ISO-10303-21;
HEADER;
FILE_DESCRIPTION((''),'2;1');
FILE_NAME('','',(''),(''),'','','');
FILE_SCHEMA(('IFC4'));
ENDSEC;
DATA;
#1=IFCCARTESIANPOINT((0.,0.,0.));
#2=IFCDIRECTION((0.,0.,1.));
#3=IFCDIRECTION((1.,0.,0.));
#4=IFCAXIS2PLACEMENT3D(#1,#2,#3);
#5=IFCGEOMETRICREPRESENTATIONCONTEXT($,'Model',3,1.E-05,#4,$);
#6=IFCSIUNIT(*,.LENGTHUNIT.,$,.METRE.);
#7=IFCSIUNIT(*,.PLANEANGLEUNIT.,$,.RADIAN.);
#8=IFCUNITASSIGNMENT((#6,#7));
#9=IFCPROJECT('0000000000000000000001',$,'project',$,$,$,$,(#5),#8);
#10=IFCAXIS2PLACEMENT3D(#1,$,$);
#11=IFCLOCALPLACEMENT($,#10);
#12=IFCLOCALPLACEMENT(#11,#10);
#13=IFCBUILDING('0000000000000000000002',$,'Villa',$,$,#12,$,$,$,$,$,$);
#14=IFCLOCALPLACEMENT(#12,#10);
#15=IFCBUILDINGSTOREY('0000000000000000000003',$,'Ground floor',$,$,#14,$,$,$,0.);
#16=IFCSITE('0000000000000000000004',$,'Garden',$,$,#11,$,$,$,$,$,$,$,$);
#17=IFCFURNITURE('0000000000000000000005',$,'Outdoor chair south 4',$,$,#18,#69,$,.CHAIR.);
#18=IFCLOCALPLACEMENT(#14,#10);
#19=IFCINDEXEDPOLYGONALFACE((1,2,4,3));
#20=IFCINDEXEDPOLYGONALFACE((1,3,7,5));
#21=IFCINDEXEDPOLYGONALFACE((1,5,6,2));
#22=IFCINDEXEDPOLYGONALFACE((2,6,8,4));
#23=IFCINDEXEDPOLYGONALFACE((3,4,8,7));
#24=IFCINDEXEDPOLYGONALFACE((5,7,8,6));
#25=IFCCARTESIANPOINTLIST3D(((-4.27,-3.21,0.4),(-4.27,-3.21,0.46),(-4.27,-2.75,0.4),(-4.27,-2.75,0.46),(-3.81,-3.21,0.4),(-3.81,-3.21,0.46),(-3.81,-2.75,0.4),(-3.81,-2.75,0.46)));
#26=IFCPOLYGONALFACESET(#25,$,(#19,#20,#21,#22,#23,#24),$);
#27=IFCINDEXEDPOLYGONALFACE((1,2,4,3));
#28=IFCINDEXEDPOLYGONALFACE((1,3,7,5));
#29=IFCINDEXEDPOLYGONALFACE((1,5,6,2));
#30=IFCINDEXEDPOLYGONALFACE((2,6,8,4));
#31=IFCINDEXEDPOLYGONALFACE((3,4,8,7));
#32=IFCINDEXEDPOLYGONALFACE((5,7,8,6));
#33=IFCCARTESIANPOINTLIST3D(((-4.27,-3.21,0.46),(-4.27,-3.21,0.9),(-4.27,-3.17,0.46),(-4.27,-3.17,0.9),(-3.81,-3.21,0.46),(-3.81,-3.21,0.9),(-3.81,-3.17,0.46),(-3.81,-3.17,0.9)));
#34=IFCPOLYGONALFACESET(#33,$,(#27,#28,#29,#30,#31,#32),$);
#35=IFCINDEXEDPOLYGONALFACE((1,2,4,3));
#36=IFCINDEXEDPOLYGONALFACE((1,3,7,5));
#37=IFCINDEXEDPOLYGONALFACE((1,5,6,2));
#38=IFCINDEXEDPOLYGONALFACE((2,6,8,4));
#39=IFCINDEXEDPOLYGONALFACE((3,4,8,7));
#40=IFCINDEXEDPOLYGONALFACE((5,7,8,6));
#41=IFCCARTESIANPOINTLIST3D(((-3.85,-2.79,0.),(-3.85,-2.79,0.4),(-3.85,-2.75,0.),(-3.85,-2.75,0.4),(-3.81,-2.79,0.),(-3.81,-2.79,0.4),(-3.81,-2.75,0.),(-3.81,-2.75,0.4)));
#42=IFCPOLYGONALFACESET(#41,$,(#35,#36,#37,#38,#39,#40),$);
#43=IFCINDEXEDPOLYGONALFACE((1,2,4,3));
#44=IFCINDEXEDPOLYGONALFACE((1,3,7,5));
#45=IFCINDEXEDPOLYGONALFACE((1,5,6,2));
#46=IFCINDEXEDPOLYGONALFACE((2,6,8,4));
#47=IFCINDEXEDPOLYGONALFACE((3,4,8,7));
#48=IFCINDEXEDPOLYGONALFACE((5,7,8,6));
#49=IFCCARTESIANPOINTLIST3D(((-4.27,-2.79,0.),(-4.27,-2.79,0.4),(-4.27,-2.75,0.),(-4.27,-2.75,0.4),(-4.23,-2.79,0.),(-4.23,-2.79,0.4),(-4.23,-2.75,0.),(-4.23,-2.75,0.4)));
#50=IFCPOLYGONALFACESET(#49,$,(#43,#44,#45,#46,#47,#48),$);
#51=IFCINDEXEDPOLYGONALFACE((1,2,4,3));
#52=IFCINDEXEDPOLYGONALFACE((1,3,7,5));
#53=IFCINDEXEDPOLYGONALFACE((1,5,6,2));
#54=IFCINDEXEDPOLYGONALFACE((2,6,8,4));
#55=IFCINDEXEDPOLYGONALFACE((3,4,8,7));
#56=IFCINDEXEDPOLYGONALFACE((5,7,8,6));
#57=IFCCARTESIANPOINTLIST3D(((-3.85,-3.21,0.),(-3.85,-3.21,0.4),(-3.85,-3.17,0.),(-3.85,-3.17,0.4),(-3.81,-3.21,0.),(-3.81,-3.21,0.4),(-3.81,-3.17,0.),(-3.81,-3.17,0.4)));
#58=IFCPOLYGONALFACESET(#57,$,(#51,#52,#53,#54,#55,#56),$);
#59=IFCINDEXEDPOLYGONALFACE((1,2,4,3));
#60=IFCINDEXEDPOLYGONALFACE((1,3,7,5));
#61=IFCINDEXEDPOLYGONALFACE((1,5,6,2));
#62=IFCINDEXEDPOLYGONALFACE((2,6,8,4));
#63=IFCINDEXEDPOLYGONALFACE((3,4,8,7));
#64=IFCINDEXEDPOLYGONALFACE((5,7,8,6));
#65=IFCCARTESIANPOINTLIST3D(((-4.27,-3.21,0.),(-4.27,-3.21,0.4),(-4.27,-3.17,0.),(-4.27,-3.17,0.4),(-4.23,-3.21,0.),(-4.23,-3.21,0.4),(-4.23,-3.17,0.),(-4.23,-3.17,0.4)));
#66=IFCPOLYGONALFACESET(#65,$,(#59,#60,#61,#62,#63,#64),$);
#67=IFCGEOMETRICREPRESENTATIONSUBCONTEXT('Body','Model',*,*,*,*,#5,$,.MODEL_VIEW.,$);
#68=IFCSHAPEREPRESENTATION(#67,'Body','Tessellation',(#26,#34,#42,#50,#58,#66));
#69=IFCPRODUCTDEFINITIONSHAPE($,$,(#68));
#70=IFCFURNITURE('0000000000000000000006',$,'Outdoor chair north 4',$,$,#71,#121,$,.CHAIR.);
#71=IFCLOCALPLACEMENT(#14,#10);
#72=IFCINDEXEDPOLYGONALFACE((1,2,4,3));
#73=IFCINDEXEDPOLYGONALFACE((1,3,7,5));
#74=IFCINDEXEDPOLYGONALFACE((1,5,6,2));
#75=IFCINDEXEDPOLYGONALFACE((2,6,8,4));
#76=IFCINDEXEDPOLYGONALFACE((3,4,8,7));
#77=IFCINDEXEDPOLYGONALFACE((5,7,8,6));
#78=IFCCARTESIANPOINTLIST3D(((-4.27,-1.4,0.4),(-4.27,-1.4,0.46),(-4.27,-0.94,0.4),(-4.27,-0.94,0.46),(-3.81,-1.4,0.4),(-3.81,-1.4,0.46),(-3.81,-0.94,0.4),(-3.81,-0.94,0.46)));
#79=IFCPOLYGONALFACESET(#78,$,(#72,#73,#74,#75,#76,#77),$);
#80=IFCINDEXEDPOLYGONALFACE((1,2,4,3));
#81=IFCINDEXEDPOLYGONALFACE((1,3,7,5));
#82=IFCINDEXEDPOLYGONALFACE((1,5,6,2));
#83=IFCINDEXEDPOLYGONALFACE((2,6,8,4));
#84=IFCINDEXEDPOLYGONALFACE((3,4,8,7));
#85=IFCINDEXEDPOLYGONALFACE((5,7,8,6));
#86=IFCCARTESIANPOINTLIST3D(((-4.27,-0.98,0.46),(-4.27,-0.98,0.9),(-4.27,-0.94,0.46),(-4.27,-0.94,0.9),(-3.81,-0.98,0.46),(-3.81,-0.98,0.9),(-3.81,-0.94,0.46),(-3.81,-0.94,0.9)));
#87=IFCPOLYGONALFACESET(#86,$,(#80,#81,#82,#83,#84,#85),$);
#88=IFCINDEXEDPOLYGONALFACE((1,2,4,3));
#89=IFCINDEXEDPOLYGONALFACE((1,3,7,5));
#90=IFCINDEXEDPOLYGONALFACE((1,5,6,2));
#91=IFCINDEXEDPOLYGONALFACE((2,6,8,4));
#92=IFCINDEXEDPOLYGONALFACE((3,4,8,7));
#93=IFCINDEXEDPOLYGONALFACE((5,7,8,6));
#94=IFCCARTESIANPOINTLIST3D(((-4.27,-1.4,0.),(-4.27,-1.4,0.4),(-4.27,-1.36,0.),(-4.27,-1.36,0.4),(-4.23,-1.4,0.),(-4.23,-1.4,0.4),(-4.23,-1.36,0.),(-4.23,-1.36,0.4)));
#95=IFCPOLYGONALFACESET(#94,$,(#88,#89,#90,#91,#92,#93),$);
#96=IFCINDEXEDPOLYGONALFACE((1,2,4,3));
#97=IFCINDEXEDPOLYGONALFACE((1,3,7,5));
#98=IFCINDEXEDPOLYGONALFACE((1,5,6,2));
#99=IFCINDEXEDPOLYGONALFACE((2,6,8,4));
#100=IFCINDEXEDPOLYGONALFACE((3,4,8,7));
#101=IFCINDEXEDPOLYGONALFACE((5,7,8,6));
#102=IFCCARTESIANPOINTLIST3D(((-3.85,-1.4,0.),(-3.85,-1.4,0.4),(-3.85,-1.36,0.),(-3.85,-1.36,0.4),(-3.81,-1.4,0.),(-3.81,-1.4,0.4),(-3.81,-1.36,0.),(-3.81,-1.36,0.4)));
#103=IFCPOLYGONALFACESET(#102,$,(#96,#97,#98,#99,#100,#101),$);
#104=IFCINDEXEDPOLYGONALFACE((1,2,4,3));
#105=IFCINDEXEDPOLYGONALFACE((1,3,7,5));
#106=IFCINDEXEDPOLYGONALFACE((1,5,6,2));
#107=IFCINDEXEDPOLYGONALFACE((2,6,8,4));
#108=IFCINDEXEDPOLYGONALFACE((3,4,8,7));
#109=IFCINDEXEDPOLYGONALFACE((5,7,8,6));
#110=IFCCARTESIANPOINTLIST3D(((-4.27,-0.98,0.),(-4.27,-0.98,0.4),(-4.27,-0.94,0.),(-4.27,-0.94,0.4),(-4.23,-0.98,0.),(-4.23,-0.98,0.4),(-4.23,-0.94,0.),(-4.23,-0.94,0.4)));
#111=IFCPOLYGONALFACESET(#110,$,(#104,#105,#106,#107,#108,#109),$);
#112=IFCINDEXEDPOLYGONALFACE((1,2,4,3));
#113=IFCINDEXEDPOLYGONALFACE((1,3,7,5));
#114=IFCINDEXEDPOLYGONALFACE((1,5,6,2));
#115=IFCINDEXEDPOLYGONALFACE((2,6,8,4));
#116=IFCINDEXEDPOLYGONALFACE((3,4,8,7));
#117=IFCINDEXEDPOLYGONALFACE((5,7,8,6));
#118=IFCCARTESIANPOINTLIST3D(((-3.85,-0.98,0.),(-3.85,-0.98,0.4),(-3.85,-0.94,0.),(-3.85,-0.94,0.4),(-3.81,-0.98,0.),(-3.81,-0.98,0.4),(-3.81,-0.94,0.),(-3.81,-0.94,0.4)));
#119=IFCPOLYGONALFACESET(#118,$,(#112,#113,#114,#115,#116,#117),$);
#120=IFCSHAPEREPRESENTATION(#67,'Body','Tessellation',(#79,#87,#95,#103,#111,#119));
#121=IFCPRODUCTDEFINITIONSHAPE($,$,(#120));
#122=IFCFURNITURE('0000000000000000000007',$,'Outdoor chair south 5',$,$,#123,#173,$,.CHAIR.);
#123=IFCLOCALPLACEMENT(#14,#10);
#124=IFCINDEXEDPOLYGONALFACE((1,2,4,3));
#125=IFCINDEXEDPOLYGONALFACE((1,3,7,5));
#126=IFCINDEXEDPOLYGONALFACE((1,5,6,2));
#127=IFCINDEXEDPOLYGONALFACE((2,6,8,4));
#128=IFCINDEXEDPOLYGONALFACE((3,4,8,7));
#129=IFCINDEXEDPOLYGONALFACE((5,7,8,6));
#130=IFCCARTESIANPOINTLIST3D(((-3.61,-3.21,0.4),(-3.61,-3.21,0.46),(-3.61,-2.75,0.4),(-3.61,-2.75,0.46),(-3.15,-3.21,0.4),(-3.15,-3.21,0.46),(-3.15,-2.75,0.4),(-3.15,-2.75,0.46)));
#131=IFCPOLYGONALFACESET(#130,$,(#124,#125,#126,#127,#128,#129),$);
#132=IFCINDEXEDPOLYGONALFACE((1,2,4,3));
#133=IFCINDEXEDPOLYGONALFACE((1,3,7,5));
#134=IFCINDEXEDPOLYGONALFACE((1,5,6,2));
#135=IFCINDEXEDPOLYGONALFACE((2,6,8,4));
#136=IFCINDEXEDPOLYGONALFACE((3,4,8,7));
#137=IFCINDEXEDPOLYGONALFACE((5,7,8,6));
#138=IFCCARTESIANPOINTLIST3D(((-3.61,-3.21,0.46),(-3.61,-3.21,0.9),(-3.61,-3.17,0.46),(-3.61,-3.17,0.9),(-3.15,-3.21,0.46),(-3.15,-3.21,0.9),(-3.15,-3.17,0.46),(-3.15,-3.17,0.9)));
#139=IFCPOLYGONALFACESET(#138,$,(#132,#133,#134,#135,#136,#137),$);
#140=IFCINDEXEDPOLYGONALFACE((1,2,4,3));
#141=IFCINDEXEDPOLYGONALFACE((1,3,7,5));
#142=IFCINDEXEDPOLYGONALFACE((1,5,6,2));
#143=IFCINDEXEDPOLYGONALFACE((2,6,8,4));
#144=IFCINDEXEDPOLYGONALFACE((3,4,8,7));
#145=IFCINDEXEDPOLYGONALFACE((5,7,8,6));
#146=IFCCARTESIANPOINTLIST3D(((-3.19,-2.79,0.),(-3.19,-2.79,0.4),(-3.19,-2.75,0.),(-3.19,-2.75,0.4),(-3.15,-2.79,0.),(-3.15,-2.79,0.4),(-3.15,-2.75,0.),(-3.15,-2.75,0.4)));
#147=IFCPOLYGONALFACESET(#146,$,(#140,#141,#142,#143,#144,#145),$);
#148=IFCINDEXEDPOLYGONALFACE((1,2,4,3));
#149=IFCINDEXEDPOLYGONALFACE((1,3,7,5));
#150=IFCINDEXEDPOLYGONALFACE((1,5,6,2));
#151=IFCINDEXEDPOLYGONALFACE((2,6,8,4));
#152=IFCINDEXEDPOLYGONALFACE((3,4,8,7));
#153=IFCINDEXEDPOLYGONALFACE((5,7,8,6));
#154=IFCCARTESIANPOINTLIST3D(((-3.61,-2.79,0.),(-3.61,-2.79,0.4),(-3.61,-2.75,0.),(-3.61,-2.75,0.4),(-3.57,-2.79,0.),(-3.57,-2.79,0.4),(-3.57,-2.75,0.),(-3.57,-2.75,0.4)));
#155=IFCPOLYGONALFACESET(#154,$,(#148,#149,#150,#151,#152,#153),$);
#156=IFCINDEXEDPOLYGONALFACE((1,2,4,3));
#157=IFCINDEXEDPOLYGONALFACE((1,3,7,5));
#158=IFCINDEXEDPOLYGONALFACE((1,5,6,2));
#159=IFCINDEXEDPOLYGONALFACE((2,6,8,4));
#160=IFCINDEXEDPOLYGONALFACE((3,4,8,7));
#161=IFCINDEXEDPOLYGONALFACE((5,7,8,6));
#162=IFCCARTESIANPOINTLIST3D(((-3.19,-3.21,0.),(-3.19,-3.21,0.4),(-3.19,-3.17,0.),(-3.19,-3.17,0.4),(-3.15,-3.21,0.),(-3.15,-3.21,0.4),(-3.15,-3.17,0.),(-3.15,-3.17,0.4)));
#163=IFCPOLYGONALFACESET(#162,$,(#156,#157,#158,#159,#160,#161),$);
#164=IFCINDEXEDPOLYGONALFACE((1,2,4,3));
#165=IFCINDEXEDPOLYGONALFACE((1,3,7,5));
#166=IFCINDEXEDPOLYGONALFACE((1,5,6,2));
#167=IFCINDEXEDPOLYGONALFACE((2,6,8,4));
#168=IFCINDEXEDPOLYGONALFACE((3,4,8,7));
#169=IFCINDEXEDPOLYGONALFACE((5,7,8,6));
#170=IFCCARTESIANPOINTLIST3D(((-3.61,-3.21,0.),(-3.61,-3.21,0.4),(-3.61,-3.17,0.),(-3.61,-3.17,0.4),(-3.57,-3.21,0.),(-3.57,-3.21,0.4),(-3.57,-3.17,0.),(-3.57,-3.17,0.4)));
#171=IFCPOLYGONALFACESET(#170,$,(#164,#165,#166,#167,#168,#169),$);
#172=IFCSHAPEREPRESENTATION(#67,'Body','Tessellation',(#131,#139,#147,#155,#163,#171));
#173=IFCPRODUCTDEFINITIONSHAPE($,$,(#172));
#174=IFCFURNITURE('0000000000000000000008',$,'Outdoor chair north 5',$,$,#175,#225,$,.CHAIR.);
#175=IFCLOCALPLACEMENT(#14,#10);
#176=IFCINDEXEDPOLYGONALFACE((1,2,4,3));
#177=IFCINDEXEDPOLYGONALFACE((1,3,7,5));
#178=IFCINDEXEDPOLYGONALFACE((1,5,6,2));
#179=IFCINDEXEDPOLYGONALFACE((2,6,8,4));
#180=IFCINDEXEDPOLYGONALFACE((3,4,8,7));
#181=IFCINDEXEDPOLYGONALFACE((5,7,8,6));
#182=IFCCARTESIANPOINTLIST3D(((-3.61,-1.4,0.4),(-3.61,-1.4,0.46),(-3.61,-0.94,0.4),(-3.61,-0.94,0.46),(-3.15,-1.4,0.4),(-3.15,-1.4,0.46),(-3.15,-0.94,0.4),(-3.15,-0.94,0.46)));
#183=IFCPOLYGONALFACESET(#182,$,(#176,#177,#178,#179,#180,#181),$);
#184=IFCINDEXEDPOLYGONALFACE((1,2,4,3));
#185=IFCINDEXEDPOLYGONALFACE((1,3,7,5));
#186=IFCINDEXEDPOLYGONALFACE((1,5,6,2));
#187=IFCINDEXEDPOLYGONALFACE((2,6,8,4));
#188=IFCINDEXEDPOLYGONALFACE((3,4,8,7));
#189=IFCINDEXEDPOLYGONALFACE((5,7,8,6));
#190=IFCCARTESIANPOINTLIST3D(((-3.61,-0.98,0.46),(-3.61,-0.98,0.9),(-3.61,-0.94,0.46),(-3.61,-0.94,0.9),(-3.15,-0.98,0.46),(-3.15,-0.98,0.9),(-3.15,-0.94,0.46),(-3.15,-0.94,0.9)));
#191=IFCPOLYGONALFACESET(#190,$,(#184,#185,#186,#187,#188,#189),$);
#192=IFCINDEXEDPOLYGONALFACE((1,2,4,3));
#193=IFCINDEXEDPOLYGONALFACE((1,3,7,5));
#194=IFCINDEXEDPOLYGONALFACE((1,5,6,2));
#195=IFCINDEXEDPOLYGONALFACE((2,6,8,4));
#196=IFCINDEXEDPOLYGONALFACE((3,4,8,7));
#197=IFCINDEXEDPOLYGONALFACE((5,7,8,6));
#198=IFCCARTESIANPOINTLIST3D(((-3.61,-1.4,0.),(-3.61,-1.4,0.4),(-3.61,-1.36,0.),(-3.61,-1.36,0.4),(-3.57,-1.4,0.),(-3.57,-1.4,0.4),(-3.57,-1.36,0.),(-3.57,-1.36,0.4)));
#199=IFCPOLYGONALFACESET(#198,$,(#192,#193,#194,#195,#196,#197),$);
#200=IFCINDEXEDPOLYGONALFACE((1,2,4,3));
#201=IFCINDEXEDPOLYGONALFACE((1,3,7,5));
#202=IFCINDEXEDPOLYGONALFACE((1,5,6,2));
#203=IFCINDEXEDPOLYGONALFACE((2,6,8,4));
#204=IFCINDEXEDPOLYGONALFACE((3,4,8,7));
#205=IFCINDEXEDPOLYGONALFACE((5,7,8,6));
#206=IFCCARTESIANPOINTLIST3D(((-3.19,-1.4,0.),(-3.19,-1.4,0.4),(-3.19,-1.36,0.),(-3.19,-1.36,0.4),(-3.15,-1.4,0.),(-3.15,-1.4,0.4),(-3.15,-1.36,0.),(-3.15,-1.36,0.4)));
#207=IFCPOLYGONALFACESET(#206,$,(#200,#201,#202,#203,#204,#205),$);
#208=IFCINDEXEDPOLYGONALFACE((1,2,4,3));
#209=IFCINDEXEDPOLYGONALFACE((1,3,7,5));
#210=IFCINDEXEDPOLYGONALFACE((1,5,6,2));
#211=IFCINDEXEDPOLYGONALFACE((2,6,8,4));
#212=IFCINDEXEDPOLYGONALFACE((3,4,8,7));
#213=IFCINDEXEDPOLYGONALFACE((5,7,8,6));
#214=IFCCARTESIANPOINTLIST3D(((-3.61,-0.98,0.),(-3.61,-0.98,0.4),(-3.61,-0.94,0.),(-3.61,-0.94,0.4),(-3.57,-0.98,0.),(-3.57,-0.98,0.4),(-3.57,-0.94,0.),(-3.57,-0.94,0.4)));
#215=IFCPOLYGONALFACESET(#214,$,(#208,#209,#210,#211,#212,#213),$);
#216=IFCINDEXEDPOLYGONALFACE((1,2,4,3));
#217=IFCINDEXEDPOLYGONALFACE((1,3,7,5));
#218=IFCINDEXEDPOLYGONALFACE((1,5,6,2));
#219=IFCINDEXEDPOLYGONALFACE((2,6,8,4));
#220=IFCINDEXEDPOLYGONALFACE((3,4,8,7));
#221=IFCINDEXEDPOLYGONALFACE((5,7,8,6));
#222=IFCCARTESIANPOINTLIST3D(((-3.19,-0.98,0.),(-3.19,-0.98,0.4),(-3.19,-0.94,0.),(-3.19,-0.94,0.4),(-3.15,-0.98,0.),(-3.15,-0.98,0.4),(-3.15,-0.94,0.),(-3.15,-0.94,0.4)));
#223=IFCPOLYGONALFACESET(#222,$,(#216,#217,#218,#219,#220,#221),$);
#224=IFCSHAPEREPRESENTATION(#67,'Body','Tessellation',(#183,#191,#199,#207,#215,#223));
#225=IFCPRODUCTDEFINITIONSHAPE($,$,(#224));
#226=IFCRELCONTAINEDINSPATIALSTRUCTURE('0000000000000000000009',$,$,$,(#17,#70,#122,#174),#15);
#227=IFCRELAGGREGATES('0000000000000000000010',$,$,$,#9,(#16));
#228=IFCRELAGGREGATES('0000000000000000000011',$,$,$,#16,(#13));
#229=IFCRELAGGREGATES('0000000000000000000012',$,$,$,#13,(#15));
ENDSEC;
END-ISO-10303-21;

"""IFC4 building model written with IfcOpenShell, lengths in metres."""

from ifc_helpers import new_model, si_unit, frame, frame_2d, origin, origin_with_axes, place, context, subcontext, project, spatial, rectangle, extrude, element, save


model = new_model("IFC4")

# Units and contexts
model_context = context("Model", 3, precision=1e-05, world=origin_with_axes())
body_context = subcontext(model_context, "Body", "Model", "MODEL_VIEW")
ifc_project = project(units=[si_unit("LENGTHUNIT", "METRE"), si_unit("PLANEANGLEUNIT", "RADIAN")], contexts=[model_context])

# Site, building, storey
site_placement = place(None, origin())
site = spatial("IfcSite", under=ifc_project, at=site_placement, Name="Garden")
building_placement = place(site_placement, origin())
building = spatial("IfcBuilding", under=site, at=building_placement, Name="Villa")
storey_placement = place(building_placement, origin())
storey = spatial("IfcBuildingStorey", under=building, at=storey_placement, Name="Ground floor", Elevation=0.0)

# Furniture
furniture_1_placement = place(storey_placement, frame((-3.81, -2.75, 0.0), x_axis=(-1.0, 0.0, 0.0)))
element("IfcFurniture", 1, at=furniture_1_placement, inside=storey, Name="Outdoor chair south 4", PredefinedType="CHAIR", context=body_context, shape_type="SweptSolid", body=[
    extrude(rectangle(XDim=0.46, YDim=0.46, at=frame_2d((0.23, 0.23))), frame((0.0, 0.0, 0.4)), (0.0, 0.0, 1.0), 0.06),
    extrude(rectangle(XDim=0.46, YDim=0.04, at=frame_2d((0.23, 0.02))), frame((0.0, 0.42, 0.46)), (0.0, 0.0, 1.0), 0.44),
    extrude(rectangle(XDim=0.04, YDim=0.04, at=frame_2d((0.02, 0.02))), origin(), (0.0, 0.0, 1.0), 0.4),
    extrude(rectangle(XDim=0.04, YDim=0.04, at=frame_2d((0.02, 0.02))), frame((0.42, 0.0, 0.0)), (0.0, 0.0, 1.0), 0.4),
    extrude(rectangle(XDim=0.04, YDim=0.04, at=frame_2d((0.02, 0.02))), frame((0.0, 0.42, 0.0)), (0.0, 0.0, 1.0), 0.4),
    extrude(rectangle(XDim=0.04, YDim=0.04, at=frame_2d((0.02, 0.02))), frame((0.42, 0.42, 0.0)), (0.0, 0.0, 1.0), 0.4),
])
furniture_2_placement = place(storey_placement, frame((-4.27, -1.4, 0.0)))
element("IfcFurniture", 2, at=furniture_2_placement, inside=storey, Name="Outdoor chair north 4", PredefinedType="CHAIR", context=body_context, shape_type="SweptSolid", body=[
    extrude(rectangle(XDim=0.46, YDim=0.46, at=frame_2d((0.23, 0.23))), frame((0.0, 0.0, 0.4)), (0.0, 0.0, 1.0), 0.06),
    extrude(rectangle(XDim=0.46, YDim=0.04, at=frame_2d((0.23, 0.02))), frame((0.0, 0.42, 0.46)), (0.0, 0.0, 1.0), 0.44),
    extrude(rectangle(XDim=0.04, YDim=0.04, at=frame_2d((0.02, 0.02))), origin(), (0.0, 0.0, 1.0), 0.4),
    extrude(rectangle(XDim=0.04, YDim=0.04, at=frame_2d((0.02, 0.02))), frame((0.42, 0.0, 0.0)), (0.0, 0.0, 1.0), 0.4),
    extrude(rectangle(XDim=0.04, YDim=0.04, at=frame_2d((0.02, 0.02))), frame((0.0, 0.42, 0.0)), (0.0, 0.0, 1.0), 0.4),
    extrude(rectangle(XDim=0.04, YDim=0.04, at=frame_2d((0.02, 0.02))), frame((0.42, 0.42, 0.0)), (0.0, 0.0, 1.0), 0.4),
])
furniture_3_placement = place(storey_placement, frame((-3.15, -2.75, 0.0), x_axis=(-1.0, 0.0, 0.0)))
element("IfcFurniture", 3, at=furniture_3_placement, inside=storey, Name="Outdoor chair south 5", PredefinedType="CHAIR", context=body_context, shape_type="SweptSolid", body=[
    extrude(rectangle(XDim=0.46, YDim=0.46, at=frame_2d((0.23, 0.23))), frame((0.0, 0.0, 0.4)), (0.0, 0.0, 1.0), 0.06),
    extrude(rectangle(XDim=0.46, YDim=0.04, at=frame_2d((0.23, 0.02))), frame((0.0, 0.42, 0.46)), (0.0, 0.0, 1.0), 0.44),
    extrude(rectangle(XDim=0.04, YDim=0.04, at=frame_2d((0.02, 0.02))), origin(), (0.0, 0.0, 1.0), 0.4),
    extrude(rectangle(XDim=0.04, YDim=0.04, at=frame_2d((0.02, 0.02))), frame((0.42, 0.0, 0.0)), (0.0, 0.0, 1.0), 0.4),
    extrude(rectangle(XDim=0.04, YDim=0.04, at=frame_2d((0.02, 0.02))), frame((0.0, 0.42, 0.0)), (0.0, 0.0, 1.0), 0.4),
    extrude(rectangle(XDim=0.04, YDim=0.04, at=frame_2d((0.02, 0.02))), frame((0.42, 0.42, 0.0)), (0.0, 0.0, 1.0), 0.4),
])
furniture_4_placement = place(storey_placement, frame((-3.61, -1.4, 0.0)))
element("IfcFurniture", 4, at=furniture_4_placement, inside=storey, Name="Outdoor chair north 5", PredefinedType="CHAIR", context=body_context, shape_type="SweptSolid", body=[
    extrude(rectangle(XDim=0.46, YDim=0.46, at=frame_2d((0.23, 0.23))), frame((0.0, 0.0, 0.4)), (0.0, 0.0, 1.0), 0.06),
    extrude(rectangle(XDim=0.46, YDim=0.04, at=frame_2d((0.23, 0.02))), frame((0.0, 0.42, 0.46)), (0.0, 0.0, 1.0), 0.44),
    extrude(rectangle(XDim=0.04, YDim=0.04, at=frame_2d((0.02, 0.02))), origin(), (0.0, 0.0, 1.0), 0.4),
    extrude(rectangle(XDim=0.04, YDim=0.04, at=frame_2d((0.02, 0.02))), frame((0.42, 0.0, 0.0)), (0.0, 0.0, 1.0), 0.4),
    extrude(rectangle(XDim=0.04, YDim=0.04, at=frame_2d((0.02, 0.02))), frame((0.0, 0.42, 0.0)), (0.0, 0.0, 1.0), 0.4),
    extrude(rectangle(XDim=0.04, YDim=0.04, at=frame_2d((0.02, 0.02))), frame((0.42, 0.42, 0.0)), (0.0, 0.0, 1.0), 0.4),
])

save(model, "model.ifc")
